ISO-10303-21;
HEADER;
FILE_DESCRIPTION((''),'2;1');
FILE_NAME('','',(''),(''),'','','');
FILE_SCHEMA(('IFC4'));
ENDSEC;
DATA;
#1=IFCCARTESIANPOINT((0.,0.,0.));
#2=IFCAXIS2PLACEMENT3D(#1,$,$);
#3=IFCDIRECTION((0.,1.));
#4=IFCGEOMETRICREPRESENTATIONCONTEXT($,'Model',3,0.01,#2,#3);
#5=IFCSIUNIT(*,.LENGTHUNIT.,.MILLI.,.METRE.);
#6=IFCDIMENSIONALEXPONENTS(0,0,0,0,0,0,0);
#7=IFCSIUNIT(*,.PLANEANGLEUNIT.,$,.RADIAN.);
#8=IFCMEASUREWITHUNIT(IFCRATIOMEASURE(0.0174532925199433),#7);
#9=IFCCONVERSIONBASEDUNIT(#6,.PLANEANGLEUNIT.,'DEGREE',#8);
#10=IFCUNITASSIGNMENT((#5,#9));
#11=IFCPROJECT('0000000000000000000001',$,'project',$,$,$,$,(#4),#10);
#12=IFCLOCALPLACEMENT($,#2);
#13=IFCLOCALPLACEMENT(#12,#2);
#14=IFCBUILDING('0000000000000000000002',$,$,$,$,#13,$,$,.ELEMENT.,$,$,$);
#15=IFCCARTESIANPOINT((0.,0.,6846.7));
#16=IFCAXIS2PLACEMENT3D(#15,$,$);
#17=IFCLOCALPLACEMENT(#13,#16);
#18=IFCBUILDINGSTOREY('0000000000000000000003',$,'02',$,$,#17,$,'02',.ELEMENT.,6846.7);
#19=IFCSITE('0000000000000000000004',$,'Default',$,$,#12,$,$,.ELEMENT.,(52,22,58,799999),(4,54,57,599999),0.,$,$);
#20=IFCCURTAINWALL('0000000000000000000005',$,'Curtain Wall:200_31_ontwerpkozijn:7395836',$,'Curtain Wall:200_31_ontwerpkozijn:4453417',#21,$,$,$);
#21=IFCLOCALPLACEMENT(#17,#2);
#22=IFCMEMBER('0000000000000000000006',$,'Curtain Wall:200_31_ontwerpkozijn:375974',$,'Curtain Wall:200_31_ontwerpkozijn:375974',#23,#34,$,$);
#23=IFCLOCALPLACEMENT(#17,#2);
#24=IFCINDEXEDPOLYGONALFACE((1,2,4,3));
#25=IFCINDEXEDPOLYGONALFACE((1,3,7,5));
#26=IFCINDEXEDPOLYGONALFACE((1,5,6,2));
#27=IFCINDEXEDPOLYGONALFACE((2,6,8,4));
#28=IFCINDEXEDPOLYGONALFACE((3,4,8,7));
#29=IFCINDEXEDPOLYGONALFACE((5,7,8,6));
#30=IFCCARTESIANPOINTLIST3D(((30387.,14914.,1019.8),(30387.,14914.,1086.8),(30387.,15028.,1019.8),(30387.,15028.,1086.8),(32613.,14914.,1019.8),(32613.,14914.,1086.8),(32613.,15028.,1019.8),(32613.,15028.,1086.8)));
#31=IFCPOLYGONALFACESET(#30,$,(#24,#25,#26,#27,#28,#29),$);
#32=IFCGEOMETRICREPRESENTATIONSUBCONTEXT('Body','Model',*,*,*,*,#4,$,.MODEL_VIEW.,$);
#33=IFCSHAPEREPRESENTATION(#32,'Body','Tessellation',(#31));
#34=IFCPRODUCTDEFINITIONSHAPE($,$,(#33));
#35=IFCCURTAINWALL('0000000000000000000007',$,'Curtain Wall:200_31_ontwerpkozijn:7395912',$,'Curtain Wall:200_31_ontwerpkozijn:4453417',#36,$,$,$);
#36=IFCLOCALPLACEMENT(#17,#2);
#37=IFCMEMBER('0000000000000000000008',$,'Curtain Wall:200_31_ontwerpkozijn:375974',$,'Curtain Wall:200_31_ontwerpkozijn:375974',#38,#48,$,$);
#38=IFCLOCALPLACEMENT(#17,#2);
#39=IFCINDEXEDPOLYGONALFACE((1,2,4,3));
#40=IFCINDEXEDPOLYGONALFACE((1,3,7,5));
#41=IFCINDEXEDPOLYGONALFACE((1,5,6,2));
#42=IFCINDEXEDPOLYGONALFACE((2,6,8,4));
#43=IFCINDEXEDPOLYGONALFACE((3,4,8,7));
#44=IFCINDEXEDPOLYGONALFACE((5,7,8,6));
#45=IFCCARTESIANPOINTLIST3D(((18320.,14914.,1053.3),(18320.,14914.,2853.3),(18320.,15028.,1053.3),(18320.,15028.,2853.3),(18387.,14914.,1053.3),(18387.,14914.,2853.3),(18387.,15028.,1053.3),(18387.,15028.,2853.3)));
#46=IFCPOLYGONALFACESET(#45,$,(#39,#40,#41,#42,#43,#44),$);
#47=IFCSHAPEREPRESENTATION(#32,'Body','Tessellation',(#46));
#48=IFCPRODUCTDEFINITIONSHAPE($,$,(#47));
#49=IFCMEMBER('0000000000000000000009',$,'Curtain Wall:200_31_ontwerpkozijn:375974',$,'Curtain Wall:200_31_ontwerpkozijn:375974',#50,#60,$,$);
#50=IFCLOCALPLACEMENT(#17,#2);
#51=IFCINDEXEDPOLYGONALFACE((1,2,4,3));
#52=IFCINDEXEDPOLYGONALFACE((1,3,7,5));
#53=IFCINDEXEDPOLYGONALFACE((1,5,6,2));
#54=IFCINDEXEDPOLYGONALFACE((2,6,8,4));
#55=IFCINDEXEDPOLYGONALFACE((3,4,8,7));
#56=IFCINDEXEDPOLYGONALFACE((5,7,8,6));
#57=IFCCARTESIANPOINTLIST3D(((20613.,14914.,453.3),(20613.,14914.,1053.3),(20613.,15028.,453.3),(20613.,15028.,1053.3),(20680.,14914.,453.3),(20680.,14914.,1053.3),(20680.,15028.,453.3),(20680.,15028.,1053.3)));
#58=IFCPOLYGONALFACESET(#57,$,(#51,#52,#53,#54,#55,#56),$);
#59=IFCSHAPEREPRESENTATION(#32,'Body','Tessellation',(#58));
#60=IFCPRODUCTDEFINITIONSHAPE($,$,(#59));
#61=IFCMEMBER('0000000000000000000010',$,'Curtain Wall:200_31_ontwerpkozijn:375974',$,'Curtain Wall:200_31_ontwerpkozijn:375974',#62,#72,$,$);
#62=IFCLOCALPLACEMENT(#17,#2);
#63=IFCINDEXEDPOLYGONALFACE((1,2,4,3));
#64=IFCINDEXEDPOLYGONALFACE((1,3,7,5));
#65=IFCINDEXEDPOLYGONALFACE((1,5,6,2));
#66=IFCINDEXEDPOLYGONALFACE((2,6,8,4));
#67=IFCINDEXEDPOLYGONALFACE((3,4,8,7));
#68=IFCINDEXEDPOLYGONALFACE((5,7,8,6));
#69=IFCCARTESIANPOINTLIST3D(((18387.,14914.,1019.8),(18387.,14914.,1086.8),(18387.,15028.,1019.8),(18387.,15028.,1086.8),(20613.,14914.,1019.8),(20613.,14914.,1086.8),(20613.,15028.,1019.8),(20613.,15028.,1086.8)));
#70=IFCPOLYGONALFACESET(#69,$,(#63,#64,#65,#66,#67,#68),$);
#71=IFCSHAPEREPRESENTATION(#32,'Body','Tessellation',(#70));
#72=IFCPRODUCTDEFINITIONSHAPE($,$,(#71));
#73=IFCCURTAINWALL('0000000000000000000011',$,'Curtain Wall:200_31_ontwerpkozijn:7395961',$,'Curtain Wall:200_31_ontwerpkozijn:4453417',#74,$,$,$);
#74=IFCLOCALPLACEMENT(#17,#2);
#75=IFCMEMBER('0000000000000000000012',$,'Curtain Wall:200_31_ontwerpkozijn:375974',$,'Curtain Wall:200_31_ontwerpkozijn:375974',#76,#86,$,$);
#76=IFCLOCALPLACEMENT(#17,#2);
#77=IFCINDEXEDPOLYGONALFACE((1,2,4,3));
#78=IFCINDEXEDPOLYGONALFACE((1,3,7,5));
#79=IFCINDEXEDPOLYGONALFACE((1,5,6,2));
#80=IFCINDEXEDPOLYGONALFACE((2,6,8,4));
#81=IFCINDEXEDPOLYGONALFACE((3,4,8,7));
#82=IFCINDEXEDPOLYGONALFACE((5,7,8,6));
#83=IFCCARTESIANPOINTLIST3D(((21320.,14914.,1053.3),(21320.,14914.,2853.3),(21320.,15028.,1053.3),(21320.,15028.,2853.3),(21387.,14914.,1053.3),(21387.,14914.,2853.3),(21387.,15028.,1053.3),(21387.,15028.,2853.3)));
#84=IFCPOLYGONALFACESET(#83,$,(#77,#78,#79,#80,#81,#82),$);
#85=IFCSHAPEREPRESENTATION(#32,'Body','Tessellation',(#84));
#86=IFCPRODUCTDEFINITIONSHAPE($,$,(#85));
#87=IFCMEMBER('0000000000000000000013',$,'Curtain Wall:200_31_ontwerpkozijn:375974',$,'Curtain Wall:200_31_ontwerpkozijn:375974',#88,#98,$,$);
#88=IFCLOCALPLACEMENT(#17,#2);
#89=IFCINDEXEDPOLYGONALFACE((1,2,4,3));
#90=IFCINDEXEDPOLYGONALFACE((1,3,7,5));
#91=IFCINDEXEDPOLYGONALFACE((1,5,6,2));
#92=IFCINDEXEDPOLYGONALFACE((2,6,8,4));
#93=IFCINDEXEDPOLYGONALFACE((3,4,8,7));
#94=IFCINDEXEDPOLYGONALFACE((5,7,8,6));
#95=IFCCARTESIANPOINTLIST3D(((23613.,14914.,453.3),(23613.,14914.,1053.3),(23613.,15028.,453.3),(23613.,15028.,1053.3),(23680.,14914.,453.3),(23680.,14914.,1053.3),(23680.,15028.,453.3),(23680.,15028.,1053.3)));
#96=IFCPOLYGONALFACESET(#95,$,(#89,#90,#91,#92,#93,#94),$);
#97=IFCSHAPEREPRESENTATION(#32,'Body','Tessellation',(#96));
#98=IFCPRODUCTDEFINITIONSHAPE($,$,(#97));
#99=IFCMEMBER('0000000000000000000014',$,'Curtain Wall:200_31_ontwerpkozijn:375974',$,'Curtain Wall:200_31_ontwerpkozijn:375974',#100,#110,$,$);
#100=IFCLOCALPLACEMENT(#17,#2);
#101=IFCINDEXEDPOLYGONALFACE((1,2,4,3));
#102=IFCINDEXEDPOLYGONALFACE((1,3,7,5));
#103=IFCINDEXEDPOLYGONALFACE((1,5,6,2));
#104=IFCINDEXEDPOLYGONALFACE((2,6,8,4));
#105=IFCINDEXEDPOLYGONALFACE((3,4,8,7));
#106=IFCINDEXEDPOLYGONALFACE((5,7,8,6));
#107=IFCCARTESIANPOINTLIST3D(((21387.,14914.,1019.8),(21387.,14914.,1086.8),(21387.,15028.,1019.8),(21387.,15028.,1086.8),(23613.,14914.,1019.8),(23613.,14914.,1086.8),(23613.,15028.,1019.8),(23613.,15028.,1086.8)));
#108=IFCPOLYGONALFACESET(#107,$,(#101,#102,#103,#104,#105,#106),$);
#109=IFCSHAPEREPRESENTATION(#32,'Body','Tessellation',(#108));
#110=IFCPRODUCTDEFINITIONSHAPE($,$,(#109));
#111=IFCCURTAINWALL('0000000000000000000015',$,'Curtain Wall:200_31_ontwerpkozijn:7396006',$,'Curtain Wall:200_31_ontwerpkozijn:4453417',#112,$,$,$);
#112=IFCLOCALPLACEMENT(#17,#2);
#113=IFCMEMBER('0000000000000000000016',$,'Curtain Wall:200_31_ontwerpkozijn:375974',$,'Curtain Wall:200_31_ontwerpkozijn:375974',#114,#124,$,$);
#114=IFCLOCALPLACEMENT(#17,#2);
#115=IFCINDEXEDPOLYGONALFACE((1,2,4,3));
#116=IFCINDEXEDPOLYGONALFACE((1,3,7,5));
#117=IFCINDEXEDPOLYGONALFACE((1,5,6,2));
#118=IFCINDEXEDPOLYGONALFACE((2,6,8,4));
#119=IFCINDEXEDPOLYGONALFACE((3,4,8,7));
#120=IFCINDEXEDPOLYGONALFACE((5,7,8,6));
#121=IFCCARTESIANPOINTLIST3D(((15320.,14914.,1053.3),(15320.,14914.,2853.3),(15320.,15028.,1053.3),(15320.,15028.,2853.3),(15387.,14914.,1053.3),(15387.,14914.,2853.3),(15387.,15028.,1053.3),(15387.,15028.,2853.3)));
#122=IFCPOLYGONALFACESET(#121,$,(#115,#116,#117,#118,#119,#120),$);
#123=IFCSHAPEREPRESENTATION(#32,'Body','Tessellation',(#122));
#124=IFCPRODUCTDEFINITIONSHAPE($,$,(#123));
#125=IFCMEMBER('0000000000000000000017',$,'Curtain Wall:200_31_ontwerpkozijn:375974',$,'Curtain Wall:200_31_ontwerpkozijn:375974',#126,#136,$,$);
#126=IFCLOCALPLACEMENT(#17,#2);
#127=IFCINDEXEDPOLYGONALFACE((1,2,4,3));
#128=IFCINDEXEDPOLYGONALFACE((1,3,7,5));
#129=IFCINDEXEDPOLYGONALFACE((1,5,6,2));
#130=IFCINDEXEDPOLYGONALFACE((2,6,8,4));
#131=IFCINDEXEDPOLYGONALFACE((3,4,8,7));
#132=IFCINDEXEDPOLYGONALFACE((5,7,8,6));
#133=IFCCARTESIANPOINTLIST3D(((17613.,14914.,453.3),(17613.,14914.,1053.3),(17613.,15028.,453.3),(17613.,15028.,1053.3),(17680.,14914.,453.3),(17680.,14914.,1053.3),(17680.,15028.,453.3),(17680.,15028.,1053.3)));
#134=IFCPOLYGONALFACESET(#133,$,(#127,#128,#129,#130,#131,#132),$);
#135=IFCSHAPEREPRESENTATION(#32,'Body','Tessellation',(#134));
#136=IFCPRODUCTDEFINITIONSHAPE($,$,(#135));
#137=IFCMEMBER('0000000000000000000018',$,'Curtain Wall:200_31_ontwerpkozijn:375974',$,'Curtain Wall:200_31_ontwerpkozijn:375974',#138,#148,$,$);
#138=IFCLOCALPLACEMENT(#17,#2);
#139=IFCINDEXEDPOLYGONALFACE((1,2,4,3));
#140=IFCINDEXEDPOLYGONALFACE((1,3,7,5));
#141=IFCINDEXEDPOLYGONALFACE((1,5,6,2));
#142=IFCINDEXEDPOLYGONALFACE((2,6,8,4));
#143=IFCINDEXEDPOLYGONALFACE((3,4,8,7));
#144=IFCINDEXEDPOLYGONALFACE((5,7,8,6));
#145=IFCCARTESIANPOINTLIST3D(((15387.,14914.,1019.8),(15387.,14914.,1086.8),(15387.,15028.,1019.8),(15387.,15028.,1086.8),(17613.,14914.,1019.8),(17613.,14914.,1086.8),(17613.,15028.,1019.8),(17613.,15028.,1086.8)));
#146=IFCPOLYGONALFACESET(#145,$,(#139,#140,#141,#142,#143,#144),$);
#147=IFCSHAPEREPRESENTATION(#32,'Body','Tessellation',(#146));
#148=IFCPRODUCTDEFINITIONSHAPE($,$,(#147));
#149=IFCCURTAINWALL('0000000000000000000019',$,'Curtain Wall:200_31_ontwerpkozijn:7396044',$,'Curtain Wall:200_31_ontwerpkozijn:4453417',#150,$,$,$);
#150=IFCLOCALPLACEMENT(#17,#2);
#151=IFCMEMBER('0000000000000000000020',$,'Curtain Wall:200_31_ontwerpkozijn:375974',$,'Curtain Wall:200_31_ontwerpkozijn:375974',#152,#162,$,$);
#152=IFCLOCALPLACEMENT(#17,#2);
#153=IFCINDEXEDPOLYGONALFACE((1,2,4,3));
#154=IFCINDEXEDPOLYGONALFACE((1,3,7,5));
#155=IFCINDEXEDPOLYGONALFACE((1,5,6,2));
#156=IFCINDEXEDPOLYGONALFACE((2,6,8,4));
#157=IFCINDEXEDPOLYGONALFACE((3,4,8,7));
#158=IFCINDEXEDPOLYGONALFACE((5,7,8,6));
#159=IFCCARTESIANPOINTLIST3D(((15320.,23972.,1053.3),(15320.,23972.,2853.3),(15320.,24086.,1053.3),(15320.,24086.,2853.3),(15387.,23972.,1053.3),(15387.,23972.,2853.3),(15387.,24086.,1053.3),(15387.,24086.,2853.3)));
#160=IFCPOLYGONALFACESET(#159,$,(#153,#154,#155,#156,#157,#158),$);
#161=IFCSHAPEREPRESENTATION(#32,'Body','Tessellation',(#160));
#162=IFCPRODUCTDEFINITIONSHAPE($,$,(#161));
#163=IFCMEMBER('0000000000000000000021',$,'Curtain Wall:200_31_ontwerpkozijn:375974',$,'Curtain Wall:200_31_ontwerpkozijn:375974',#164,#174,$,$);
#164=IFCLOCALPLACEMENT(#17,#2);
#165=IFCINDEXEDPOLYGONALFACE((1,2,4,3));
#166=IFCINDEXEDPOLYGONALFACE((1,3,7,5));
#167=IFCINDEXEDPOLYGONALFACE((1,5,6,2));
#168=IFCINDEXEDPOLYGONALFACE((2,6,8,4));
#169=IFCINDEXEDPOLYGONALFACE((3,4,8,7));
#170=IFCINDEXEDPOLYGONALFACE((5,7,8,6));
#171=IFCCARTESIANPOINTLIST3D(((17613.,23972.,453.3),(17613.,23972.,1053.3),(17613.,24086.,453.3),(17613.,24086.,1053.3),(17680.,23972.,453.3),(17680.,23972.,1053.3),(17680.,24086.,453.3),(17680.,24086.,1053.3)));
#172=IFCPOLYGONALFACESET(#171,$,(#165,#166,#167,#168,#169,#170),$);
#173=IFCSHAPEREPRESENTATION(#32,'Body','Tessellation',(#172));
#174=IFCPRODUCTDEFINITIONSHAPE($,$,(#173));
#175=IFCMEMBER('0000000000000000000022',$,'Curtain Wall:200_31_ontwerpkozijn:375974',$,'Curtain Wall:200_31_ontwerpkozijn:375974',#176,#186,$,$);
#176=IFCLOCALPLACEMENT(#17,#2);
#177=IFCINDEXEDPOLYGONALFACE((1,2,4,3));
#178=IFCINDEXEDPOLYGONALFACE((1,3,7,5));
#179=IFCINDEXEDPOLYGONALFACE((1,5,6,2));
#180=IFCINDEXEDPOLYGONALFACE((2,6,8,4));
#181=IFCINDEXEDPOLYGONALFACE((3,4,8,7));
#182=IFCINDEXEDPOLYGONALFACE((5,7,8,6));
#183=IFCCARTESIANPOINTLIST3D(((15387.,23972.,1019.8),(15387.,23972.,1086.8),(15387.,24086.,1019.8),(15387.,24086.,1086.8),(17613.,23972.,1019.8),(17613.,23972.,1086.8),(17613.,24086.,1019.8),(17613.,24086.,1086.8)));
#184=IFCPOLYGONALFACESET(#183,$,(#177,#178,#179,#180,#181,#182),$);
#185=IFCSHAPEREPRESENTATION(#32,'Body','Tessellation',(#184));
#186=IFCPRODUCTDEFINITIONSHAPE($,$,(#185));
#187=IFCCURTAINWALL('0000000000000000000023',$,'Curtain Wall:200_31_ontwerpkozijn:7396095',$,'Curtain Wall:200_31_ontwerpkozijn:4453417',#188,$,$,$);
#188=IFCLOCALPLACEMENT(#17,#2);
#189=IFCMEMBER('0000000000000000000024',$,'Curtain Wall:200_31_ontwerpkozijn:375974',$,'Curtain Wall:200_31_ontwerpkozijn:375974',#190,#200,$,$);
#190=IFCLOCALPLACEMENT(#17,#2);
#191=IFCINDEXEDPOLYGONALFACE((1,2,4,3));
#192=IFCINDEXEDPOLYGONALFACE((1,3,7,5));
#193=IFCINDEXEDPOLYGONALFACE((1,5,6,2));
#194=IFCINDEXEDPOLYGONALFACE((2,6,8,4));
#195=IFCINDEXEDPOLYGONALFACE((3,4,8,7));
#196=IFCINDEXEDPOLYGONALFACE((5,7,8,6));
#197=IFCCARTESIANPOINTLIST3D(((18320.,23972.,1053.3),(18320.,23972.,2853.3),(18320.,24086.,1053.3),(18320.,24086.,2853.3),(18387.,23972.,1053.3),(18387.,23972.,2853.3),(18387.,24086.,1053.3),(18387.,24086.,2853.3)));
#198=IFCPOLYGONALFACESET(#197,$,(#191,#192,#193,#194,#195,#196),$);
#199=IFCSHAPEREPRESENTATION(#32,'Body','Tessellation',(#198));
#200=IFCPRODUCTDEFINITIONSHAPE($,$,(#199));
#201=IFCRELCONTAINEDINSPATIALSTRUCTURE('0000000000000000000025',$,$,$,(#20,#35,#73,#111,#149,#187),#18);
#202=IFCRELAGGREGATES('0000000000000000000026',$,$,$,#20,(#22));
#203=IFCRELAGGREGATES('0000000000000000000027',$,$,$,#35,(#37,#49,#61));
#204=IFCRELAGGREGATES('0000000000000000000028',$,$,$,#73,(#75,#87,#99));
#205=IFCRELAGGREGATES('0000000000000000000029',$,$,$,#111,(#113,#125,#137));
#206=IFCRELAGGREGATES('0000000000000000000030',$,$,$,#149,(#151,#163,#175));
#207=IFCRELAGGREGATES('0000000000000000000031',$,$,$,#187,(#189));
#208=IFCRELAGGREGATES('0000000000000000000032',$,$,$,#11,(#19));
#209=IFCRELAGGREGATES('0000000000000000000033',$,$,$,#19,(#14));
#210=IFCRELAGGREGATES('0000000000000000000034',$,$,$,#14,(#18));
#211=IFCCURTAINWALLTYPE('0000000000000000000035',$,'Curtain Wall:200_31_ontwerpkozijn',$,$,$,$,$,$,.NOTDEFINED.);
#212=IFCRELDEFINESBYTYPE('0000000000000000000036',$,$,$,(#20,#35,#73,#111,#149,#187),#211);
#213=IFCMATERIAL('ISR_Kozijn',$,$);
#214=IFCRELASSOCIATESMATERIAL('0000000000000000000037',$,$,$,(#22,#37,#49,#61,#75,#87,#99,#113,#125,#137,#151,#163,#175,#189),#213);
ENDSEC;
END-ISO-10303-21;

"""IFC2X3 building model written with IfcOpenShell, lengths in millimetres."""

from ifc_helpers import new_model, entity, si_unit, converted_unit, direction, frame, frame_2d, origin, origin_2d_with_axis, place, context, subcontext, project, spatial, rectangle, extrude, material, type_object, element, aggregate, save


model = new_model("IFC2X3")

# Units and contexts
model_context = context("Model", 3, precision=0.01, world=origin(), true_north=direction((0.0, 1.0)))
body_context = subcontext(model_context, "Body", "Model", "MODEL_VIEW")
ifc_project = project(units=[si_unit("LENGTHUNIT", "METRE", prefix="MILLI"), converted_unit("PLANEANGLEUNIT", "DEGREE", entity("IfcRatioMeasure", 0.0174532925199433), si_unit("PLANEANGLEUNIT", "RADIAN"), dimensions=[0, 0, 0, 0, 0, 0, 0])], contexts=[model_context])

# Site, building, storey
site_placement = place(None, origin())
site = spatial("IfcSite", under=ifc_project, at=site_placement, Name="Default", CompositionType="ELEMENT", RefLatitude=(52, 22, 58, 799999), RefLongitude=(4, 54, 57, 599999), RefElevation=0.0)
building_placement = place(site_placement, origin())
building = spatial("IfcBuilding", under=site, at=building_placement, CompositionType="ELEMENT")
storey_placement = place(building_placement, frame((0.0, 0.0, 6846.7)))
storey = spatial("IfcBuildingStorey", under=building, at=storey_placement, Name="02", LongName="02", CompositionType="ELEMENT", Elevation=6846.7)

# Curtain walls, members
curtain_wall_type = type_object("IfcCurtainWallType", Name="Curtain Wall:200_31_ontwerpkozijn", PredefinedType="NOTDEFINED")
ifc_material = material(Name="ISR_Kozijn")
curtain_wall_1_placement = place(storey_placement, frame((0.0, 0.0, -6846.7)))
curtain_wall_1 = element("IfcCurtainWall", 1, at=curtain_wall_1_placement, inside=storey, type_object=curtain_wall_type, Name="Curtain Wall:200_31_ontwerpkozijn:7395836", ObjectType="Curtain Wall:200_31_ontwerpkozijn:4453417")
member_1_placement = place(curtain_wall_1_placement, frame((0.0, 0.0, 6846.7)))
member_1 = element("IfcMember", 2, at=member_1_placement, material=ifc_material, Name="Curtain Wall:200_31_ontwerpkozijn:375974", ObjectType="Curtain Wall:200_31_ontwerpkozijn:375974", context=body_context, shape_type="SweptSolid", body=[
    extrude(rectangle(XDim=67.0, YDim=114.0, at=frame_2d((0.0, 0.0), x_axis=(1.0, 0.0))), frame((30387.0, 14971.0, 1053.3), z_axis=(1.0, 0.0, 0.0), x_axis=(0.0, 0.0, -1.0)), (0.0, 0.0, 1.0), 2226.0),
])
aggregate(curtain_wall_1, [member_1])
curtain_wall_2_placement = place(storey_placement, frame((0.0, 0.0, -6846.7)))
curtain_wall_2 = element("IfcCurtainWall", 3, at=curtain_wall_2_placement, inside=storey, type_object=curtain_wall_type, Name="Curtain Wall:200_31_ontwerpkozijn:7395912", ObjectType="Curtain Wall:200_31_ontwerpkozijn:4453417")
member_2_placement = place(curtain_wall_2_placement, frame((0.0, 0.0, 6846.7)))
member_2 = element("IfcMember", 4, at=member_2_placement, material=ifc_material, Name="Curtain Wall:200_31_ontwerpkozijn:375974", ObjectType="Curtain Wall:200_31_ontwerpkozijn:375974", context=body_context, shape_type="SweptSolid", body=[
    extrude(rectangle(XDim=67.0, YDim=114.0, at=frame_2d((0.0, 0.0), x_axis=(1.0, 0.0))), frame((18353.5, 14971.0, 1053.3), z_axis=(0.0, 0.0, 1.0), x_axis=(-1.0, 0.0, 0.0)), (0.0, 0.0, 1.0), 1800.0),
])
member_3_placement = place(curtain_wall_2_placement, frame((0.0, 0.0, 6846.7)))
member_3 = element("IfcMember", 5, at=member_3_placement, material=ifc_material, Name="Curtain Wall:200_31_ontwerpkozijn:375974", ObjectType="Curtain Wall:200_31_ontwerpkozijn:375974", context=body_context, shape_type="SweptSolid", body=[
    extrude(rectangle(XDim=67.0, YDim=114.0, at=origin_2d_with_axis()), frame((20646.5, 14971.0, 1053.3), z_axis=(0.0, 0.0, -1.0), x_axis=(-1.0, 0.0, 0.0)), (0.0, 0.0, 1.0), 600.0),
])
member_4_placement = place(curtain_wall_2_placement, frame((0.0, 0.0, 6846.7)))
member_4 = element("IfcMember", 6, at=member_4_placement, material=ifc_material, Name="Curtain Wall:200_31_ontwerpkozijn:375974", ObjectType="Curtain Wall:200_31_ontwerpkozijn:375974", context=body_context, shape_type="SweptSolid", body=[
    extrude(rectangle(XDim=67.0, YDim=114.0, at=frame_2d((0.0, 0.0), x_axis=(1.0, 0.0))), frame((18387.0, 14971.0, 1053.3), z_axis=(1.0, 0.0, 0.0), x_axis=(0.0, 0.0, -1.0)), (0.0, 0.0, 1.0), 2226.0),
])
aggregate(curtain_wall_2, [member_2, member_3, member_4])
curtain_wall_3_placement = place(storey_placement, frame((0.0, 0.0, -6846.7)))
curtain_wall_3 = element("IfcCurtainWall", 7, at=curtain_wall_3_placement, inside=storey, type_object=curtain_wall_type, Name="Curtain Wall:200_31_ontwerpkozijn:7395961", ObjectType="Curtain Wall:200_31_ontwerpkozijn:4453417")
member_5_placement = place(curtain_wall_3_placement, frame((0.0, 0.0, 6846.7)))
member_5 = element("IfcMember", 8, at=member_5_placement, material=ifc_material, Name="Curtain Wall:200_31_ontwerpkozijn:375974", ObjectType="Curtain Wall:200_31_ontwerpkozijn:375974", context=body_context, shape_type="SweptSolid", body=[
    extrude(rectangle(XDim=67.0, YDim=114.0, at=origin_2d_with_axis()), frame((21353.5, 14971.0, 1053.3), z_axis=(0.0, 0.0, 1.0), x_axis=(-1.0, 0.0, 0.0)), (0.0, 0.0, 1.0), 1800.0),
])
member_6_placement = place(curtain_wall_3_placement, frame((0.0, 0.0, 6846.7)))
member_6 = element("IfcMember", 9, at=member_6_placement, material=ifc_material, Name="Curtain Wall:200_31_ontwerpkozijn:375974", ObjectType="Curtain Wall:200_31_ontwerpkozijn:375974", context=body_context, shape_type="SweptSolid", body=[
    extrude(rectangle(XDim=67.0, YDim=114.0, at=origin_2d_with_axis()), frame((23646.5, 14971.0, 1053.3), z_axis=(0.0, 0.0, -1.0), x_axis=(-1.0, 0.0, 0.0)), (0.0, 0.0, 1.0), 600.0),
])
member_7_placement = place(curtain_wall_3_placement, frame((0.0, 0.0, 6846.7)))
member_7 = element("IfcMember", 10, at=member_7_placement, material=ifc_material, Name="Curtain Wall:200_31_ontwerpkozijn:375974", ObjectType="Curtain Wall:200_31_ontwerpkozijn:375974", context=body_context, shape_type="SweptSolid", body=[
    extrude(rectangle(XDim=67.0, YDim=114.0, at=frame_2d((0.0, 0.0), x_axis=(1.0, 0.0))), frame((21387.0, 14971.0, 1053.3), z_axis=(1.0, 0.0, 0.0), x_axis=(0.0, 0.0, -1.0)), (0.0, 0.0, 1.0), 2226.0),
])
aggregate(curtain_wall_3, [member_5, member_6, member_7])
curtain_wall_4_placement = place(storey_placement, frame((0.0, 0.0, -6846.7)))
curtain_wall_4 = element("IfcCurtainWall", 11, at=curtain_wall_4_placement, inside=storey, type_object=curtain_wall_type, Name="Curtain Wall:200_31_ontwerpkozijn:7396006", ObjectType="Curtain Wall:200_31_ontwerpkozijn:4453417")
member_8_placement = place(curtain_wall_4_placement, frame((0.0, 0.0, 6846.7)))
member_8 = element("IfcMember", 12, at=member_8_placement, material=ifc_material, Name="Curtain Wall:200_31_ontwerpkozijn:375974", ObjectType="Curtain Wall:200_31_ontwerpkozijn:375974", context=body_context, shape_type="SweptSolid", body=[
    extrude(rectangle(XDim=67.0, YDim=114.0, at=frame_2d((0.0, 0.0), x_axis=(1.0, 0.0))), frame((15353.5, 14971.0, 1053.3), z_axis=(0.0, 0.0, 1.0), x_axis=(-1.0, 0.0, 0.0)), (0.0, 0.0, 1.0), 1800.0),
])
member_9_placement = place(curtain_wall_4_placement, frame((0.0, 0.0, 6846.7)))
member_9 = element("IfcMember", 13, at=member_9_placement, material=ifc_material, Name="Curtain Wall:200_31_ontwerpkozijn:375974", ObjectType="Curtain Wall:200_31_ontwerpkozijn:375974", context=body_context, shape_type="SweptSolid", body=[
    extrude(rectangle(XDim=67.0, YDim=114.0, at=frame_2d((0.0, 0.0), x_axis=(1.0, 0.0))), frame((17646.5, 14971.0, 1053.3), z_axis=(0.0, 0.0, -1.0), x_axis=(-1.0, 0.0, 0.0)), (0.0, 0.0, 1.0), 600.0),
])
member_10_placement = place(curtain_wall_4_placement, frame((0.0, 0.0, 6846.7)))
member_10 = element("IfcMember", 14, at=member_10_placement, material=ifc_material, Name="Curtain Wall:200_31_ontwerpkozijn:375974", ObjectType="Curtain Wall:200_31_ontwerpkozijn:375974", context=body_context, shape_type="SweptSolid", body=[
    extrude(rectangle(XDim=67.0, YDim=114.0, at=frame_2d((0.0, 0.0), x_axis=(1.0, 0.0))), frame((15387.0, 14971.0, 1053.3), z_axis=(1.0, 0.0, 0.0), x_axis=(0.0, 0.0, -1.0)), (0.0, 0.0, 1.0), 2226.0),
])
aggregate(curtain_wall_4, [member_8, member_9, member_10])
curtain_wall_5_placement = place(storey_placement, frame((0.0, 0.0, -6846.7)))
curtain_wall_5 = element("IfcCurtainWall", 15, at=curtain_wall_5_placement, inside=storey, type_object=curtain_wall_type, Name="Curtain Wall:200_31_ontwerpkozijn:7396044", ObjectType="Curtain Wall:200_31_ontwerpkozijn:4453417")
member_11_placement = place(curtain_wall_5_placement, frame((0.0, 0.0, 6846.7)))
member_11 = element("IfcMember", 16, at=member_11_placement, material=ifc_material, Name="Curtain Wall:200_31_ontwerpkozijn:375974", ObjectType="Curtain Wall:200_31_ontwerpkozijn:375974", context=body_context, shape_type="SweptSolid", body=[
    extrude(rectangle(XDim=67.0, YDim=114.0, at=frame_2d((0.0, 0.0), x_axis=(1.0, 0.0))), frame((15353.5, 24029.0, 1053.3), z_axis=(0.0, 0.0, 1.0), x_axis=(-1.0, 0.0, 0.0)), (0.0, 0.0, 1.0), 1800.0),
])
member_12_placement = place(curtain_wall_5_placement, frame((0.0, 0.0, 6846.7)))
member_12 = element("IfcMember", 17, at=member_12_placement, material=ifc_material, Name="Curtain Wall:200_31_ontwerpkozijn:375974", ObjectType="Curtain Wall:200_31_ontwerpkozijn:375974", context=body_context, shape_type="SweptSolid", body=[
    extrude(rectangle(XDim=67.0, YDim=114.0, at=frame_2d((0.0, 0.0), x_axis=(1.0, 0.0))), frame((17646.5, 24029.0, 1053.3), z_axis=(0.0, 0.0, -1.0), x_axis=(-1.0, 0.0, 0.0)), (0.0, 0.0, 1.0), 600.0),
])
member_13_placement = place(curtain_wall_5_placement, frame((0.0, 0.0, 6846.7)))
member_13 = element("IfcMember", 18, at=member_13_placement, material=ifc_material, Name="Curtain Wall:200_31_ontwerpkozijn:375974", ObjectType="Curtain Wall:200_31_ontwerpkozijn:375974", context=body_context, shape_type="SweptSolid", body=[
    extrude(rectangle(XDim=67.0, YDim=114.0, at=frame_2d((0.0, 0.0), x_axis=(1.0, 0.0))), frame((15387.0, 24029.0, 1053.3), z_axis=(1.0, 0.0, 0.0), x_axis=(0.0, 0.0, -1.0)), (0.0, 0.0, 1.0), 2226.0),
])
aggregate(curtain_wall_5, [member_11, member_12, member_13])
curtain_wall_6_placement = place(storey_placement, frame((0.0, 0.0, -6846.7)))
curtain_wall_6 = element("IfcCurtainWall", 19, at=curtain_wall_6_placement, inside=storey, type_object=curtain_wall_type, Name="Curtain Wall:200_31_ontwerpkozijn:7396095", ObjectType="Curtain Wall:200_31_ontwerpkozijn:4453417")
member_14_placement = place(curtain_wall_6_placement, frame((0.0, 0.0, 6846.7)))
member_14 = element("IfcMember", 20, at=member_14_placement, material=ifc_material, Name="Curtain Wall:200_31_ontwerpkozijn:375974", ObjectType="Curtain Wall:200_31_ontwerpkozijn:375974", context=body_context, shape_type="SweptSolid", body=[
    extrude(rectangle(XDim=67.0, YDim=114.0, at=frame_2d((0.0, 0.0), x_axis=(1.0, 0.0))), frame((18353.5, 24029.0, 1053.3), z_axis=(0.0, 0.0, 1.0), x_axis=(-1.0, 0.0, 0.0)), (0.0, 0.0, 1.0), 1800.0),
])
aggregate(curtain_wall_6, [member_14])

save(model, "model.ifc")
